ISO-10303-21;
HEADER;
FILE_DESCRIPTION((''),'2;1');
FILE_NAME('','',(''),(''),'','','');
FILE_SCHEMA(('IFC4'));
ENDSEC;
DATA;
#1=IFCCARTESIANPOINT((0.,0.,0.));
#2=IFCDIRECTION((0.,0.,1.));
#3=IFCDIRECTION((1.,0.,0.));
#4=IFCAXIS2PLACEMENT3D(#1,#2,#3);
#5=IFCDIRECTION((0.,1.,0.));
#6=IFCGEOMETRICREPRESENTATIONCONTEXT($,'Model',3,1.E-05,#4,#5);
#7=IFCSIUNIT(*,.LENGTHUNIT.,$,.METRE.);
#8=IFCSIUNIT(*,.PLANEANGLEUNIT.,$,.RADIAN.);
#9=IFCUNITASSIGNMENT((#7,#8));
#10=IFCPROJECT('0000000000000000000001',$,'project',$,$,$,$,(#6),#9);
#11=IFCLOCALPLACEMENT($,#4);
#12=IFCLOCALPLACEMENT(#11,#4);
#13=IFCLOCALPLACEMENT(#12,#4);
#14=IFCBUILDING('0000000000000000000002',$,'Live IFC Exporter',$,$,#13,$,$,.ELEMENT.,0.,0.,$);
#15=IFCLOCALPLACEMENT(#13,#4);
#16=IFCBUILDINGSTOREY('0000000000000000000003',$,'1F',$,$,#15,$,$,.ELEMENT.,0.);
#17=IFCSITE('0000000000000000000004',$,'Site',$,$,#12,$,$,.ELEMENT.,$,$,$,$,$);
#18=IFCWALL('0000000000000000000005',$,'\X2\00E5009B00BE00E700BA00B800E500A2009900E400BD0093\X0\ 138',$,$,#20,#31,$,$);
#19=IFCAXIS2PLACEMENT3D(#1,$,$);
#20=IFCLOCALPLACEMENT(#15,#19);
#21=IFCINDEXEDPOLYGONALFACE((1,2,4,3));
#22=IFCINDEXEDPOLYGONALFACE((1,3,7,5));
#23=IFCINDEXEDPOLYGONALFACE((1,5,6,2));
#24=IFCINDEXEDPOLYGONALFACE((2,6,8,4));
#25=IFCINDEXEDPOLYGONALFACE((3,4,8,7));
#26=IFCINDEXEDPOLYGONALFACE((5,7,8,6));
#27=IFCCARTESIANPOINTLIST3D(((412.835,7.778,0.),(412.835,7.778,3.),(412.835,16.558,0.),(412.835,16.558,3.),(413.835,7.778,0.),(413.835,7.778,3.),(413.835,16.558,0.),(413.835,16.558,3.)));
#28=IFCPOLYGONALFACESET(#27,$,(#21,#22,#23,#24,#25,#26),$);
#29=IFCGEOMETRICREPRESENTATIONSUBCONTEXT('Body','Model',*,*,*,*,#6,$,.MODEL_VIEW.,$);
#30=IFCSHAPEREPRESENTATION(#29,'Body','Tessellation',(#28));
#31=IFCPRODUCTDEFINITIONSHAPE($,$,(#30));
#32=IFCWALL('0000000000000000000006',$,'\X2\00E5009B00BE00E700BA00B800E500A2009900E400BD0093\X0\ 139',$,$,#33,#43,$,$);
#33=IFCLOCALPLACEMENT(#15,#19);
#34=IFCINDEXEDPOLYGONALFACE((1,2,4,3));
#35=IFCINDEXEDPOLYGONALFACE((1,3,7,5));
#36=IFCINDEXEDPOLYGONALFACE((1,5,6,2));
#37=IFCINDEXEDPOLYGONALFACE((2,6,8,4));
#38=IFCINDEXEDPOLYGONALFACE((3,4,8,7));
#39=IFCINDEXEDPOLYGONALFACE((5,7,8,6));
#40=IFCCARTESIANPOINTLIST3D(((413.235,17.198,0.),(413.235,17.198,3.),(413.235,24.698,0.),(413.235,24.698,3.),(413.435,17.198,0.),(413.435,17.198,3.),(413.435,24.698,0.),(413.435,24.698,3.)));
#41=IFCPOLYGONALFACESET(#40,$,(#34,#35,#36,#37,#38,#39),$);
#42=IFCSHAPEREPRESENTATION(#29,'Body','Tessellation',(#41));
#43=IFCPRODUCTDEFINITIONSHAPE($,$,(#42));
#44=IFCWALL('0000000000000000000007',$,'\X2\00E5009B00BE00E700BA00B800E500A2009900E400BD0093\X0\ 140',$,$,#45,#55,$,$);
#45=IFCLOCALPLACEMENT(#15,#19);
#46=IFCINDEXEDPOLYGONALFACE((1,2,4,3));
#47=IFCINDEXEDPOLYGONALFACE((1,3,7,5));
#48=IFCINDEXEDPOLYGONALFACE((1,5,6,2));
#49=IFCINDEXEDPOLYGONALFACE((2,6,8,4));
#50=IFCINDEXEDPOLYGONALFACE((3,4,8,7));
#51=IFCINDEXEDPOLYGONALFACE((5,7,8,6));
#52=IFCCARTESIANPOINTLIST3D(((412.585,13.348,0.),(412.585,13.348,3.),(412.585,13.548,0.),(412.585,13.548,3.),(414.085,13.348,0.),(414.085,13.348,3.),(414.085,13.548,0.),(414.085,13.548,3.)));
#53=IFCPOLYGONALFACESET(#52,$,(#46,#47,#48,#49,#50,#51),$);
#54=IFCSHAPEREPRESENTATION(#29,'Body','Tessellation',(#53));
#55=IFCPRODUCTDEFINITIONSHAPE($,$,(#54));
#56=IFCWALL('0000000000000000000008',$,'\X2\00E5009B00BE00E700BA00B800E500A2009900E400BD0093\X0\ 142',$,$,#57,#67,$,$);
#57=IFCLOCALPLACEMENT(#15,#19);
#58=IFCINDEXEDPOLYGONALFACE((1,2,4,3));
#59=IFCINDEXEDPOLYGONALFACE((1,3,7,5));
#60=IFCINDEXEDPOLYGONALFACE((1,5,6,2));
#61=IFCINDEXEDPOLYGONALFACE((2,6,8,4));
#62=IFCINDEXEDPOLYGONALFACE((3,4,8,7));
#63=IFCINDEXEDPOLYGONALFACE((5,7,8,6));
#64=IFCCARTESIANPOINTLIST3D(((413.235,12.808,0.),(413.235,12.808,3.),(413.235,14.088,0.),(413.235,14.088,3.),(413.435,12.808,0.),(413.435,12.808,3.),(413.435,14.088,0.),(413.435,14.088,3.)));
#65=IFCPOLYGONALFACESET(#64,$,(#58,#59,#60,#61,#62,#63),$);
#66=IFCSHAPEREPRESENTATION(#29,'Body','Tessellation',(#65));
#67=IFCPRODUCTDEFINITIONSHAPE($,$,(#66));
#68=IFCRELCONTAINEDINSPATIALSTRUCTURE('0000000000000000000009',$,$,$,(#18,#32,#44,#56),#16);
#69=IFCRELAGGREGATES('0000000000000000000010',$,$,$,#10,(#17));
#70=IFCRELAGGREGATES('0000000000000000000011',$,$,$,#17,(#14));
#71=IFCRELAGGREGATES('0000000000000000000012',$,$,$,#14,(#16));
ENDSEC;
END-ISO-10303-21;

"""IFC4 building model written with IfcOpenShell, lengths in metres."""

from ifc_helpers import new_model, si_unit, direction, frame, frame_2d, origin_with_axes, place, context, subcontext, project, spatial, rectangle, extrude, element, save


model = new_model("IFC4")

# Units and contexts
model_context = context("Model", 3, precision=1e-05, world=origin_with_axes(), true_north=direction((0.0, 1.0, 0.0)))
body_context = subcontext(model_context, "Body", "Model", "MODEL_VIEW")
ifc_project = project(units=[si_unit("LENGTHUNIT", "METRE"), si_unit("PLANEANGLEUNIT", "RADIAN")], contexts=[model_context])

# Site, building, storey
placement = place(None, origin_with_axes())
site_placement = place(placement, origin_with_axes())
site = spatial("IfcSite", under=ifc_project, at=site_placement, Name="Site", CompositionType="ELEMENT")
building_placement = place(site_placement, origin_with_axes())
building = spatial("IfcBuilding", under=site, at=building_placement, Name="Live IFC Exporter", CompositionType="ELEMENT", ElevationOfRefHeight=0.0, ElevationOfTerrain=0.0)
storey_placement = place(building_placement, origin_with_axes())
storey = spatial("IfcBuildingStorey", under=building, at=storey_placement, Name="1F", CompositionType="ELEMENT", Elevation=0.0)

# Walls
wall_1_placement = place(storey_placement, frame((413.335, 12.168, 0.0), z_axis=(0.0, 0.0, 1.0), x_axis=(1.0, 0.0, 0.0)))
element("IfcWall", 1, at=wall_1_placement, inside=storey, Name="å\u009b¾çº¸å¢\u0099ä½\u0093 138", context=body_context, shape_type="SweptSolid", body=[
    extrude(rectangle(XDim=1.0, YDim=8.78, at=frame_2d((0.0, 0.0), x_axis=(1.0, 0.0, 0.0))), frame((0.0, 0.0, 0.0), z_axis=(0.0, 0.0, 1.0)), (0.0, 0.0, 1.0), 3.0),
])
wall_2_placement = place(storey_placement, frame((413.335, 20.948, 0.0), z_axis=(0.0, 0.0, 1.0), x_axis=(0.0, -1.0, 0.0)))
element("IfcWall", 2, at=wall_2_placement, inside=storey, Name="å\u009b¾çº¸å¢\u0099ä½\u0093 139", context=body_context, shape_type="SweptSolid", body=[
    extrude(rectangle(XDim=7.5, YDim=0.2, at=frame_2d((0.0, 0.0), x_axis=(1.0, 0.0, 0.0))), frame((0.0, 0.0, 0.0), z_axis=(0.0, 0.0, 1.0)), (0.0, 0.0, 1.0), 3.0),
])
wall_3_placement = place(storey_placement, frame((413.335, 13.448, 0.0), z_axis=(0.0, 0.0, 1.0), x_axis=(1.0, 0.0, 0.0)))
element("IfcWall", 3, at=wall_3_placement, inside=storey, Name="å\u009b¾çº¸å¢\u0099ä½\u0093 140", context=body_context, shape_type="SweptSolid", body=[
    extrude(rectangle(XDim=1.5, YDim=0.2, at=frame_2d((0.0, 0.0), x_axis=(1.0, 0.0, 0.0))), frame((0.0, 0.0, 0.0), z_axis=(0.0, 0.0, 1.0)), (0.0, 0.0, 1.0), 3.0),
])
wall_4_placement = place(storey_placement, frame((413.335, 13.448, 0.0), z_axis=(0.0, 0.0, 1.0), x_axis=(0.0, -1.0, 0.0)))
element("IfcWall", 4, at=wall_4_placement, inside=storey, Name="å\u009b¾çº¸å¢\u0099ä½\u0093 142", context=body_context, shape_type="SweptSolid", body=[
    extrude(rectangle(XDim=1.28, YDim=0.2, at=frame_2d((0.0, 0.0), x_axis=(1.0, 0.0, 0.0))), frame((0.0, 0.0, 0.0), z_axis=(0.0, 0.0, 1.0)), (0.0, 0.0, 1.0), 3.0),
])

save(model, "model.ifc")
